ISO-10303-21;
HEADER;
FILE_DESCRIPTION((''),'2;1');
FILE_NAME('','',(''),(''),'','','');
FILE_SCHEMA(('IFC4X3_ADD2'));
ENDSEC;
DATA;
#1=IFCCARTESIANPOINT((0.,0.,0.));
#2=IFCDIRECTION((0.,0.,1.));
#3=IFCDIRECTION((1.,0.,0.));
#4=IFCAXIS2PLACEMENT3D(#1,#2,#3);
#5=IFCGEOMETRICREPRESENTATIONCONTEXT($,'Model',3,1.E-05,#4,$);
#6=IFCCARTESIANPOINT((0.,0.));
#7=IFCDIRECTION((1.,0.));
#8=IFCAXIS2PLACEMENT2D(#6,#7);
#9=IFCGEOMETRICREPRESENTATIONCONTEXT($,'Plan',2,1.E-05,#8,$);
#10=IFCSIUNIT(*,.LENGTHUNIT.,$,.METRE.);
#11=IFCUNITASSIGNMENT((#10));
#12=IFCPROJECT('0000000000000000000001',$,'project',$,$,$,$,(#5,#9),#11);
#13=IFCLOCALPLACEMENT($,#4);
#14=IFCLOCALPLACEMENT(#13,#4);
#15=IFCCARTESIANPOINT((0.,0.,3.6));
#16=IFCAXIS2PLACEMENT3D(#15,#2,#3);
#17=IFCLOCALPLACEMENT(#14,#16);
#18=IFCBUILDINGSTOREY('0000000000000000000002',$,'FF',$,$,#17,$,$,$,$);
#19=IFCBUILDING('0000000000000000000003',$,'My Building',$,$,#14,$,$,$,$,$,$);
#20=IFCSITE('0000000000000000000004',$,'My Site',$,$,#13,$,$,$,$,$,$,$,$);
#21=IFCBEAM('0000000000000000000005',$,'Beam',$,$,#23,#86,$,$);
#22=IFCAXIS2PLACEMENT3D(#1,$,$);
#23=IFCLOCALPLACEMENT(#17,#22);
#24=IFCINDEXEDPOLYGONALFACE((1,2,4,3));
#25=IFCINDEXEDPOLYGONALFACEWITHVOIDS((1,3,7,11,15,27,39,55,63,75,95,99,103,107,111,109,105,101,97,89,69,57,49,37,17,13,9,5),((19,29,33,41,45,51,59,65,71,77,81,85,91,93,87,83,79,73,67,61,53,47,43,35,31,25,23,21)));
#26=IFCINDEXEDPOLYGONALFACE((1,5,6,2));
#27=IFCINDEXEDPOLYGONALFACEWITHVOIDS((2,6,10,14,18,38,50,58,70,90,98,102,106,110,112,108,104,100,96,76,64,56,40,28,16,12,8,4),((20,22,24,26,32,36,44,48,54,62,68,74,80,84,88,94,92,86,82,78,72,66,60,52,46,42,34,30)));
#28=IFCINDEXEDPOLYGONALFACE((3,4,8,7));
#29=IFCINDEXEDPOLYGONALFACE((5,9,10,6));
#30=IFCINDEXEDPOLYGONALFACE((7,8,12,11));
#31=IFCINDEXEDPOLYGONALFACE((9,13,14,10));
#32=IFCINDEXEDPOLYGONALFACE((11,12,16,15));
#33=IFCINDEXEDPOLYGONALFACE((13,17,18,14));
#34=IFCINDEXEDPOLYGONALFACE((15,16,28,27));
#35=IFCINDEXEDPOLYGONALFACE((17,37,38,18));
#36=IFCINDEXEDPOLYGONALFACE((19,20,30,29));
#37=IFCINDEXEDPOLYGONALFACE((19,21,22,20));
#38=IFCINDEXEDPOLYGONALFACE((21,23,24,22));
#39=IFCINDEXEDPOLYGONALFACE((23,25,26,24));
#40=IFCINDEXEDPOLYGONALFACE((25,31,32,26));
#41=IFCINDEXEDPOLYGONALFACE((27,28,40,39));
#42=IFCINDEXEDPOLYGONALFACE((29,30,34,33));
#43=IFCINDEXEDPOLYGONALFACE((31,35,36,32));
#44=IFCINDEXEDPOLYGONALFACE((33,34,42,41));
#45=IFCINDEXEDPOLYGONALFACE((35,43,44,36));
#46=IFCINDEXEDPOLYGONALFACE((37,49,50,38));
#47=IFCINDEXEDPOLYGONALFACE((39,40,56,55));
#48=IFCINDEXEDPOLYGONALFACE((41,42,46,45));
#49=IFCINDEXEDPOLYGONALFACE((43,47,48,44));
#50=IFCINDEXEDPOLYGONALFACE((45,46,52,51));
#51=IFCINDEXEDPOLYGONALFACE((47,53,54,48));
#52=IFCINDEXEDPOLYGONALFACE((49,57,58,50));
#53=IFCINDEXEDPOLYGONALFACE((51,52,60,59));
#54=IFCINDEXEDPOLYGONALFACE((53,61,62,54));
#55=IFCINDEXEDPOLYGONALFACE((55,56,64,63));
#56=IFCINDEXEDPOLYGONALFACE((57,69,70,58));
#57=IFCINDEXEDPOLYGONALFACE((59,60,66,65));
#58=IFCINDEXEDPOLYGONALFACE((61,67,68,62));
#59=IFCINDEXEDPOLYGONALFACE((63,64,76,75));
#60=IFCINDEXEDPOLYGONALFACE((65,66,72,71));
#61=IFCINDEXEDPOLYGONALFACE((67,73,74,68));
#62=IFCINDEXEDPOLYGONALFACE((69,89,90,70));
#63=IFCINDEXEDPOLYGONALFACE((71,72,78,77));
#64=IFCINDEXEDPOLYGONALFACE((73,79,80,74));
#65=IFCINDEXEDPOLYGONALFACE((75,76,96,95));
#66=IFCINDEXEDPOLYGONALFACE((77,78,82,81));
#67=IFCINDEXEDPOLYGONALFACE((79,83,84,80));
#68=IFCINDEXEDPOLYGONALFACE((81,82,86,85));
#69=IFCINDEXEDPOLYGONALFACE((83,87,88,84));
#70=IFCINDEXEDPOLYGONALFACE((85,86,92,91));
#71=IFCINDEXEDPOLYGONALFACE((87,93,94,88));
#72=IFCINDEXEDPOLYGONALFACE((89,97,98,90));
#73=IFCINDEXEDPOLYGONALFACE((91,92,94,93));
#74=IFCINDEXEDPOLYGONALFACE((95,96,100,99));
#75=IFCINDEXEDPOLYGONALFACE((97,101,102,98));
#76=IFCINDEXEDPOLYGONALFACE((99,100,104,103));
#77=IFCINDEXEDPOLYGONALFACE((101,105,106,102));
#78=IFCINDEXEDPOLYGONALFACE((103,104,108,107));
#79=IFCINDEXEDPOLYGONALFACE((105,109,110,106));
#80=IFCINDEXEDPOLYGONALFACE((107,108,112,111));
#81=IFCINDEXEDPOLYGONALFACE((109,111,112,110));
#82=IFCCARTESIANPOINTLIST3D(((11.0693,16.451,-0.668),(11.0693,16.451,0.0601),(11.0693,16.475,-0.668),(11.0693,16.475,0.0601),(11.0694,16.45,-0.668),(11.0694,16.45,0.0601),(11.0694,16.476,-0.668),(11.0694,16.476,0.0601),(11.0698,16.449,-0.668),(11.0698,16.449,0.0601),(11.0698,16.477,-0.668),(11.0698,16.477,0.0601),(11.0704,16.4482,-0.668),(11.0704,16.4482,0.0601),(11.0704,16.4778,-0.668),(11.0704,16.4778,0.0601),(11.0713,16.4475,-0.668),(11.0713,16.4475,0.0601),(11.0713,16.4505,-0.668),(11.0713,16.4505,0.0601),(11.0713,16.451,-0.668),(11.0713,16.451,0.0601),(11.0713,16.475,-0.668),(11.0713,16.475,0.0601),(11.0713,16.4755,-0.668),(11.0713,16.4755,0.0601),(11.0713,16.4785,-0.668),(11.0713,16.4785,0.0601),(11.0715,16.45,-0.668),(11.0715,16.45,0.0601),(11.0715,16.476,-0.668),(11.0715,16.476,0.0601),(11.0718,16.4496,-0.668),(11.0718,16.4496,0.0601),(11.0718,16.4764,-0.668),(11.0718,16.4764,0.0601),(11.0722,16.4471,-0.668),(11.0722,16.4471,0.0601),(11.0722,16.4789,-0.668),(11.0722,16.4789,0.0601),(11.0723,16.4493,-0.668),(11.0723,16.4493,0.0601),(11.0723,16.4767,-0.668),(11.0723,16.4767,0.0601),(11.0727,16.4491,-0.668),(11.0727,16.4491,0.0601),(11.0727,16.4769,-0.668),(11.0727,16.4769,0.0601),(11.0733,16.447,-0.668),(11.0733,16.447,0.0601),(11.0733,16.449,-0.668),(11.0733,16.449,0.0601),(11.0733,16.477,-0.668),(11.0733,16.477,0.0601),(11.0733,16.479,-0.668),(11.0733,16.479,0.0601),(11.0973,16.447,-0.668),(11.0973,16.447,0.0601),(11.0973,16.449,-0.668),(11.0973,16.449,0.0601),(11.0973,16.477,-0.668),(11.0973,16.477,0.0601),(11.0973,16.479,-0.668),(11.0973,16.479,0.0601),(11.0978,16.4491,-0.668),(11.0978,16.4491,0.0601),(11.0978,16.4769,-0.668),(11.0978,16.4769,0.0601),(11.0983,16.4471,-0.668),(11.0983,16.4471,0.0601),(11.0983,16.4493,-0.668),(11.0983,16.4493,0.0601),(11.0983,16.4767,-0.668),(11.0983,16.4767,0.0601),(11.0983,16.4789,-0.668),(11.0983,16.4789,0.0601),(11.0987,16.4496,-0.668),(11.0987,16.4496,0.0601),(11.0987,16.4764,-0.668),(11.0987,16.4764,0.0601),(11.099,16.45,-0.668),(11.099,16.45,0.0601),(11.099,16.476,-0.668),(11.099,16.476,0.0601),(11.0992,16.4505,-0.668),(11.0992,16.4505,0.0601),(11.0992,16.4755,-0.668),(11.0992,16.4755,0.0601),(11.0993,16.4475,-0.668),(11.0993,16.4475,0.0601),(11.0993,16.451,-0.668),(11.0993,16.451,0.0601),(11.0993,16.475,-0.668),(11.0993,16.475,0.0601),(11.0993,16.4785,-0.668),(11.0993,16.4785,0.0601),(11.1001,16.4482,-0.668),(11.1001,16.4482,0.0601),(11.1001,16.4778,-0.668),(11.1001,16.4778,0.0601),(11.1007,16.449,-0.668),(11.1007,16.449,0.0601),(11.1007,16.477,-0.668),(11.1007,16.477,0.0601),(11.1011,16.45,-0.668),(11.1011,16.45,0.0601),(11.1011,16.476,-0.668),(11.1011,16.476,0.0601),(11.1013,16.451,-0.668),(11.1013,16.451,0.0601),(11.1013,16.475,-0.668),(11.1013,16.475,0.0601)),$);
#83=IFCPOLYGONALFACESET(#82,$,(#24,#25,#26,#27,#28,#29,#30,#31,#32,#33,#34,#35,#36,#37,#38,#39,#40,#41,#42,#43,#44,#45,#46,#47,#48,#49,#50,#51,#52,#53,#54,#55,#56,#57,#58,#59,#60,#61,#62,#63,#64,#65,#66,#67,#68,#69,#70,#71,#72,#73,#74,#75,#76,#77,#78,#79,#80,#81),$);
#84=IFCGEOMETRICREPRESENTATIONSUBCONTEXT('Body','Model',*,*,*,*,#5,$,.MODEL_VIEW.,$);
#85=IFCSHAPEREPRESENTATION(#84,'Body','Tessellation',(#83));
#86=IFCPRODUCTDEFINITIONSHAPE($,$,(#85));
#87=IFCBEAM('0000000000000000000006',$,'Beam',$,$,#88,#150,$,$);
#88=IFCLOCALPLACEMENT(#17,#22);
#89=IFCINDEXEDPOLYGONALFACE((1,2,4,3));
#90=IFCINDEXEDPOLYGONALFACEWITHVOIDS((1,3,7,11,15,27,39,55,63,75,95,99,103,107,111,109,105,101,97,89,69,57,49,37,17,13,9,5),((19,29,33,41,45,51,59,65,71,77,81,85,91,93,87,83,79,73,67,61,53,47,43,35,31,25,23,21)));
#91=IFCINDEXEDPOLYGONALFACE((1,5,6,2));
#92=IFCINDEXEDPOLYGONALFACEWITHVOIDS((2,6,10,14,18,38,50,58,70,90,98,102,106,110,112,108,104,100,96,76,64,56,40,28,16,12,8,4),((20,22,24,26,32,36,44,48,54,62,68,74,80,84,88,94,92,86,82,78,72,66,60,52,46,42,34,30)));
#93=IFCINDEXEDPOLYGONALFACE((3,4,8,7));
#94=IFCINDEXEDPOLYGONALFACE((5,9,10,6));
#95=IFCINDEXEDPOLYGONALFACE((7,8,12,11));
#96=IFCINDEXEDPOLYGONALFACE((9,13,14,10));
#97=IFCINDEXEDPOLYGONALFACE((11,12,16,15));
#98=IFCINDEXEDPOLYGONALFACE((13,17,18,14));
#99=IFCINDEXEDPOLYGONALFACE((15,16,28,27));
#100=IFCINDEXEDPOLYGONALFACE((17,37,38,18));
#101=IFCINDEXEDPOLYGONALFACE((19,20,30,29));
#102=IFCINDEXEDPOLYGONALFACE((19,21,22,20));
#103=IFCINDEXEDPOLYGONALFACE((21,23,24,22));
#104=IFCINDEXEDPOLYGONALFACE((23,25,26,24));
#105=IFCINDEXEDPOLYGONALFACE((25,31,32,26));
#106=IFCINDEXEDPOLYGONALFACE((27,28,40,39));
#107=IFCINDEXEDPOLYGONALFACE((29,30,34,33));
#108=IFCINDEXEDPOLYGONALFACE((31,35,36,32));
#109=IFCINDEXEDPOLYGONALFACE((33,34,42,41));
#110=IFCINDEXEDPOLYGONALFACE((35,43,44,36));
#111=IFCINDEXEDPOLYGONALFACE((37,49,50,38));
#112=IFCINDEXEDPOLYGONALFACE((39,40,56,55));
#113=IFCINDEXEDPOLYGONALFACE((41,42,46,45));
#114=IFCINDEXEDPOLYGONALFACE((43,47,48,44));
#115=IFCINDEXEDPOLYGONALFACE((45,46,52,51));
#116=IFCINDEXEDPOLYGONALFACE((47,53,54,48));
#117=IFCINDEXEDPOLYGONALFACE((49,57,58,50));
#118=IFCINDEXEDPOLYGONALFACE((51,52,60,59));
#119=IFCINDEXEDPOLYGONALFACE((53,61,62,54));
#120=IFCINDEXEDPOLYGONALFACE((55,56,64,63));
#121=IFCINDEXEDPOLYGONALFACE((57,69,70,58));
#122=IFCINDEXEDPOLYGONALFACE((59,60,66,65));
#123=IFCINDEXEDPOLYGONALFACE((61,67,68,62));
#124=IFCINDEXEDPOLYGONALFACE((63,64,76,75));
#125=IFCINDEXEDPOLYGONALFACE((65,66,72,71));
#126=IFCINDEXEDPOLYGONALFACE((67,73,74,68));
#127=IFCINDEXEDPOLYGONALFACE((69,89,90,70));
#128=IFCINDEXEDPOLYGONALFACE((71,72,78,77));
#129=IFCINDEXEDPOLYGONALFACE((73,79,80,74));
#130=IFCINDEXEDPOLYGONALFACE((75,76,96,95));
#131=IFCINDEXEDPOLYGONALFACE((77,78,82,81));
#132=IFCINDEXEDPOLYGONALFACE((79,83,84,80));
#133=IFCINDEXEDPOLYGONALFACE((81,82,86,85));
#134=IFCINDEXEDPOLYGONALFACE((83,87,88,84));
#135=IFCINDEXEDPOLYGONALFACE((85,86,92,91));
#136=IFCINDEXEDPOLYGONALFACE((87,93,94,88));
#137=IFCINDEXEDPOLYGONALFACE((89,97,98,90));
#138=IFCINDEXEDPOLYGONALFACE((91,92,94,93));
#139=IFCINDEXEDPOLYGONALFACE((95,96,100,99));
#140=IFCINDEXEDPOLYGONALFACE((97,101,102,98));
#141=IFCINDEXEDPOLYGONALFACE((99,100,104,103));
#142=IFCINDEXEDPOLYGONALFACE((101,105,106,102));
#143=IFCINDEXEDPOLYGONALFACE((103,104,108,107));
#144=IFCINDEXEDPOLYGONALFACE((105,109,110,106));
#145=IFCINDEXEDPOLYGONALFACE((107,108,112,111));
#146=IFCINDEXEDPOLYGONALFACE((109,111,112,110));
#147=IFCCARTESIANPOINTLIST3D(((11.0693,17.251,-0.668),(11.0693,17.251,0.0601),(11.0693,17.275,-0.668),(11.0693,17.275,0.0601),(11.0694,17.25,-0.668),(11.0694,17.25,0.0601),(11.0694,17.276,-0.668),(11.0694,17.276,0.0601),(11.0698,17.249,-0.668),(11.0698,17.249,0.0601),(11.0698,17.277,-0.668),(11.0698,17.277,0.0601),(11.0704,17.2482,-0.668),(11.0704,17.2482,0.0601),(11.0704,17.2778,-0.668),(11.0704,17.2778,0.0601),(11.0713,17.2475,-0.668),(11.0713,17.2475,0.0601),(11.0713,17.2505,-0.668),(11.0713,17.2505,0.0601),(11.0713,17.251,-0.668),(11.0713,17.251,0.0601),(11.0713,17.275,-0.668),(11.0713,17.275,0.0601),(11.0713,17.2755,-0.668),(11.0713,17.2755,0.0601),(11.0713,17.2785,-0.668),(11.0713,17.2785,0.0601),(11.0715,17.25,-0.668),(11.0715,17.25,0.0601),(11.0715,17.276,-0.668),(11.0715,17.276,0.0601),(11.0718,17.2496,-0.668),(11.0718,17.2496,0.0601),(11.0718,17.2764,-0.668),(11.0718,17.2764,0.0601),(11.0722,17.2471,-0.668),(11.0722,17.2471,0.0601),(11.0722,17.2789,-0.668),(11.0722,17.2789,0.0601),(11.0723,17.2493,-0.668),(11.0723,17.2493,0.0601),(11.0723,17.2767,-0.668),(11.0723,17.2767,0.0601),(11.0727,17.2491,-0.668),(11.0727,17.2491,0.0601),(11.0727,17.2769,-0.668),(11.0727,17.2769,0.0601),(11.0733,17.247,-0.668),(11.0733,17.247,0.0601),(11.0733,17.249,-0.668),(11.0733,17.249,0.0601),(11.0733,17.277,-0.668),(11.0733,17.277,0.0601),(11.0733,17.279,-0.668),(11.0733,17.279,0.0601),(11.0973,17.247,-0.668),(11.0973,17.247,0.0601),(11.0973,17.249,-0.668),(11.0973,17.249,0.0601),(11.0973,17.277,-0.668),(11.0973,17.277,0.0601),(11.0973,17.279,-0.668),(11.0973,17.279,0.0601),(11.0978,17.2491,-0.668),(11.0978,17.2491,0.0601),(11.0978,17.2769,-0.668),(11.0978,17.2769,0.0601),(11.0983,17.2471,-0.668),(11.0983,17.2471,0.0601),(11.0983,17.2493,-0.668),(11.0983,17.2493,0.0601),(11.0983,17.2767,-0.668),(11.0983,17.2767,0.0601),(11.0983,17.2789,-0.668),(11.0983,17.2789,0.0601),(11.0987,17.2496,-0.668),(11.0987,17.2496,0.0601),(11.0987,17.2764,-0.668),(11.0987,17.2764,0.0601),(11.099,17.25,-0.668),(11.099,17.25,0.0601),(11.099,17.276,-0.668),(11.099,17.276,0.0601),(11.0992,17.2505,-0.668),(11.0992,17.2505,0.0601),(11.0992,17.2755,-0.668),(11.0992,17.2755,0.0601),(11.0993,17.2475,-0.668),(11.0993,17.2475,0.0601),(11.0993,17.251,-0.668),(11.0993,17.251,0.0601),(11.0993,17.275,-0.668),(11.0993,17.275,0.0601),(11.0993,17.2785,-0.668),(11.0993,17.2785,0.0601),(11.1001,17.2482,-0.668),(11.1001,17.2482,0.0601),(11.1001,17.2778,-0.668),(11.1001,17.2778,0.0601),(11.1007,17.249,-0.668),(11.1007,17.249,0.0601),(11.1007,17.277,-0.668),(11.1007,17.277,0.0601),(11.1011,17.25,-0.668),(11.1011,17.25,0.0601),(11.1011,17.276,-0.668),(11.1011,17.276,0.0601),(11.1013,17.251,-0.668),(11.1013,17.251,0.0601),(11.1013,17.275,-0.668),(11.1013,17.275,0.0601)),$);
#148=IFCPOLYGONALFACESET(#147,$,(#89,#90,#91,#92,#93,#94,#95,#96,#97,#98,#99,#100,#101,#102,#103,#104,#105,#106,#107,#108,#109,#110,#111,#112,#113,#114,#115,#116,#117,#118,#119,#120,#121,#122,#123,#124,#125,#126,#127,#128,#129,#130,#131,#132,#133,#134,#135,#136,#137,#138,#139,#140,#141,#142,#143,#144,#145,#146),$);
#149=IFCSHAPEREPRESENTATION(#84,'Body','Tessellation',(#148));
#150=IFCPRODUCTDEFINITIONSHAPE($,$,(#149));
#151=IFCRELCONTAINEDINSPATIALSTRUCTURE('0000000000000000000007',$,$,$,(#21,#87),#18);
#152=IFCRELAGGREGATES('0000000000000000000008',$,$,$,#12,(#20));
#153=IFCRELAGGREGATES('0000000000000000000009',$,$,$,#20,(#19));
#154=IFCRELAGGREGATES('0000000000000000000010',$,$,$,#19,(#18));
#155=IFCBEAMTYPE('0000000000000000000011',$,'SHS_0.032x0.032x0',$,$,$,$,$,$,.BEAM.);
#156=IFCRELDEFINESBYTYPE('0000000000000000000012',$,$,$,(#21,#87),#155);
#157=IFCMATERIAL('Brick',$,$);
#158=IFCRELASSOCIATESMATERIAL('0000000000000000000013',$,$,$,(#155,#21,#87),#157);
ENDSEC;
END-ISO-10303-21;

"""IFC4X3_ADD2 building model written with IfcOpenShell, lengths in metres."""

from ifc_helpers import new_model, si_unit, frame, origin_with_axes, origin_2d_with_axis, place, context, subcontext, project, spatial, hollow_rectangle, extrude, material, material_profile, profile_set, profile_usage, type_object, element, save


model = new_model("IFC4X3_ADD2")

# Units and contexts
model_context = context("Model", 3, precision=1e-05, world=origin_with_axes())
plan_context = context("Plan", 2, precision=1e-05, world=origin_2d_with_axis())
body_context_1 = subcontext(model_context, "Body", "Model", "MODEL_VIEW")
ifc_project = project(units=[si_unit("LENGTHUNIT", "METRE")], contexts=[model_context, plan_context])

# Site, building, storey
site_placement = place(None, origin_with_axes())
site = spatial("IfcSite", under=ifc_project, at=site_placement, Name="My Site")
building_placement = place(site_placement, origin_with_axes())
building = spatial("IfcBuilding", under=site, at=building_placement, Name="My Building")
storey_placement = place(building_placement, frame((0.0, 0.0, 3.6), z_axis=(0.0, 0.0, 1.0), x_axis=(1.0, 0.0, 0.0)))
storey = spatial("IfcBuildingStorey", under=building, at=storey_placement, Name="FF")

# Beams
ifc_material_1 = material(Name="Brick")
ifc_material_profile_1 = material_profile(ifc_material_1, hollow_rectangle(XDim=0.032, YDim=0.032, WallThickness=0.002, InnerFilletRadius=0.002, OuterFilletRadius=0.004))
ifc_profile_set_1 = profile_set([ifc_material_profile_1])
beam_type_1 = type_object("IfcBeamType", Name="SHS_0.032x0.032x0", PredefinedType="BEAM", material=ifc_profile_set_1)
ifc_material_profile_2 = material_profile(ifc_material_1, hollow_rectangle(XDim=0.032, YDim=0.032, WallThickness=0.002, InnerFilletRadius=0.002, OuterFilletRadius=0.004))
ifc_profile_set_2 = profile_set([ifc_material_profile_2])
ifc_profile_usage_1 = profile_usage(ifc_profile_set_2, cardinal=5)
beam_1_placement = place(storey_placement, frame((11.0853, 16.463, -0.668), z_axis=(0.0, 0.0, 1.0), x_axis=(1.0, 0.0, 0.0)))
element("IfcBeam", 1, at=beam_1_placement, inside=storey, type_object=beam_type_1, material=ifc_profile_usage_1, Name="Beam", context=body_context_1, shape_type="SweptSolid", body=[
    extrude(hollow_rectangle(XDim=0.032, YDim=0.032, WallThickness=0.002, InnerFilletRadius=0.002, OuterFilletRadius=0.004), origin_with_axes(), (0.0, 0.0, 1.0), 0.7281),
])
ifc_profile_usage_2 = profile_usage(ifc_profile_set_2, cardinal=5)
beam_2_placement = place(storey_placement, frame((11.0853, 17.263, -0.668), z_axis=(0.0, 0.0, 1.0), x_axis=(1.0, 0.0, 0.0)))
element("IfcBeam", 2, at=beam_2_placement, inside=storey, type_object=beam_type_1, material=ifc_profile_usage_2, Name="Beam", context=body_context_1, shape_type="SweptSolid", body=[
    extrude(hollow_rectangle(XDim=0.032, YDim=0.032, WallThickness=0.002, InnerFilletRadius=0.002, OuterFilletRadius=0.004), origin_with_axes(), (0.0, 0.0, 1.0), 0.7281),
])

save(model, "model.ifc")
